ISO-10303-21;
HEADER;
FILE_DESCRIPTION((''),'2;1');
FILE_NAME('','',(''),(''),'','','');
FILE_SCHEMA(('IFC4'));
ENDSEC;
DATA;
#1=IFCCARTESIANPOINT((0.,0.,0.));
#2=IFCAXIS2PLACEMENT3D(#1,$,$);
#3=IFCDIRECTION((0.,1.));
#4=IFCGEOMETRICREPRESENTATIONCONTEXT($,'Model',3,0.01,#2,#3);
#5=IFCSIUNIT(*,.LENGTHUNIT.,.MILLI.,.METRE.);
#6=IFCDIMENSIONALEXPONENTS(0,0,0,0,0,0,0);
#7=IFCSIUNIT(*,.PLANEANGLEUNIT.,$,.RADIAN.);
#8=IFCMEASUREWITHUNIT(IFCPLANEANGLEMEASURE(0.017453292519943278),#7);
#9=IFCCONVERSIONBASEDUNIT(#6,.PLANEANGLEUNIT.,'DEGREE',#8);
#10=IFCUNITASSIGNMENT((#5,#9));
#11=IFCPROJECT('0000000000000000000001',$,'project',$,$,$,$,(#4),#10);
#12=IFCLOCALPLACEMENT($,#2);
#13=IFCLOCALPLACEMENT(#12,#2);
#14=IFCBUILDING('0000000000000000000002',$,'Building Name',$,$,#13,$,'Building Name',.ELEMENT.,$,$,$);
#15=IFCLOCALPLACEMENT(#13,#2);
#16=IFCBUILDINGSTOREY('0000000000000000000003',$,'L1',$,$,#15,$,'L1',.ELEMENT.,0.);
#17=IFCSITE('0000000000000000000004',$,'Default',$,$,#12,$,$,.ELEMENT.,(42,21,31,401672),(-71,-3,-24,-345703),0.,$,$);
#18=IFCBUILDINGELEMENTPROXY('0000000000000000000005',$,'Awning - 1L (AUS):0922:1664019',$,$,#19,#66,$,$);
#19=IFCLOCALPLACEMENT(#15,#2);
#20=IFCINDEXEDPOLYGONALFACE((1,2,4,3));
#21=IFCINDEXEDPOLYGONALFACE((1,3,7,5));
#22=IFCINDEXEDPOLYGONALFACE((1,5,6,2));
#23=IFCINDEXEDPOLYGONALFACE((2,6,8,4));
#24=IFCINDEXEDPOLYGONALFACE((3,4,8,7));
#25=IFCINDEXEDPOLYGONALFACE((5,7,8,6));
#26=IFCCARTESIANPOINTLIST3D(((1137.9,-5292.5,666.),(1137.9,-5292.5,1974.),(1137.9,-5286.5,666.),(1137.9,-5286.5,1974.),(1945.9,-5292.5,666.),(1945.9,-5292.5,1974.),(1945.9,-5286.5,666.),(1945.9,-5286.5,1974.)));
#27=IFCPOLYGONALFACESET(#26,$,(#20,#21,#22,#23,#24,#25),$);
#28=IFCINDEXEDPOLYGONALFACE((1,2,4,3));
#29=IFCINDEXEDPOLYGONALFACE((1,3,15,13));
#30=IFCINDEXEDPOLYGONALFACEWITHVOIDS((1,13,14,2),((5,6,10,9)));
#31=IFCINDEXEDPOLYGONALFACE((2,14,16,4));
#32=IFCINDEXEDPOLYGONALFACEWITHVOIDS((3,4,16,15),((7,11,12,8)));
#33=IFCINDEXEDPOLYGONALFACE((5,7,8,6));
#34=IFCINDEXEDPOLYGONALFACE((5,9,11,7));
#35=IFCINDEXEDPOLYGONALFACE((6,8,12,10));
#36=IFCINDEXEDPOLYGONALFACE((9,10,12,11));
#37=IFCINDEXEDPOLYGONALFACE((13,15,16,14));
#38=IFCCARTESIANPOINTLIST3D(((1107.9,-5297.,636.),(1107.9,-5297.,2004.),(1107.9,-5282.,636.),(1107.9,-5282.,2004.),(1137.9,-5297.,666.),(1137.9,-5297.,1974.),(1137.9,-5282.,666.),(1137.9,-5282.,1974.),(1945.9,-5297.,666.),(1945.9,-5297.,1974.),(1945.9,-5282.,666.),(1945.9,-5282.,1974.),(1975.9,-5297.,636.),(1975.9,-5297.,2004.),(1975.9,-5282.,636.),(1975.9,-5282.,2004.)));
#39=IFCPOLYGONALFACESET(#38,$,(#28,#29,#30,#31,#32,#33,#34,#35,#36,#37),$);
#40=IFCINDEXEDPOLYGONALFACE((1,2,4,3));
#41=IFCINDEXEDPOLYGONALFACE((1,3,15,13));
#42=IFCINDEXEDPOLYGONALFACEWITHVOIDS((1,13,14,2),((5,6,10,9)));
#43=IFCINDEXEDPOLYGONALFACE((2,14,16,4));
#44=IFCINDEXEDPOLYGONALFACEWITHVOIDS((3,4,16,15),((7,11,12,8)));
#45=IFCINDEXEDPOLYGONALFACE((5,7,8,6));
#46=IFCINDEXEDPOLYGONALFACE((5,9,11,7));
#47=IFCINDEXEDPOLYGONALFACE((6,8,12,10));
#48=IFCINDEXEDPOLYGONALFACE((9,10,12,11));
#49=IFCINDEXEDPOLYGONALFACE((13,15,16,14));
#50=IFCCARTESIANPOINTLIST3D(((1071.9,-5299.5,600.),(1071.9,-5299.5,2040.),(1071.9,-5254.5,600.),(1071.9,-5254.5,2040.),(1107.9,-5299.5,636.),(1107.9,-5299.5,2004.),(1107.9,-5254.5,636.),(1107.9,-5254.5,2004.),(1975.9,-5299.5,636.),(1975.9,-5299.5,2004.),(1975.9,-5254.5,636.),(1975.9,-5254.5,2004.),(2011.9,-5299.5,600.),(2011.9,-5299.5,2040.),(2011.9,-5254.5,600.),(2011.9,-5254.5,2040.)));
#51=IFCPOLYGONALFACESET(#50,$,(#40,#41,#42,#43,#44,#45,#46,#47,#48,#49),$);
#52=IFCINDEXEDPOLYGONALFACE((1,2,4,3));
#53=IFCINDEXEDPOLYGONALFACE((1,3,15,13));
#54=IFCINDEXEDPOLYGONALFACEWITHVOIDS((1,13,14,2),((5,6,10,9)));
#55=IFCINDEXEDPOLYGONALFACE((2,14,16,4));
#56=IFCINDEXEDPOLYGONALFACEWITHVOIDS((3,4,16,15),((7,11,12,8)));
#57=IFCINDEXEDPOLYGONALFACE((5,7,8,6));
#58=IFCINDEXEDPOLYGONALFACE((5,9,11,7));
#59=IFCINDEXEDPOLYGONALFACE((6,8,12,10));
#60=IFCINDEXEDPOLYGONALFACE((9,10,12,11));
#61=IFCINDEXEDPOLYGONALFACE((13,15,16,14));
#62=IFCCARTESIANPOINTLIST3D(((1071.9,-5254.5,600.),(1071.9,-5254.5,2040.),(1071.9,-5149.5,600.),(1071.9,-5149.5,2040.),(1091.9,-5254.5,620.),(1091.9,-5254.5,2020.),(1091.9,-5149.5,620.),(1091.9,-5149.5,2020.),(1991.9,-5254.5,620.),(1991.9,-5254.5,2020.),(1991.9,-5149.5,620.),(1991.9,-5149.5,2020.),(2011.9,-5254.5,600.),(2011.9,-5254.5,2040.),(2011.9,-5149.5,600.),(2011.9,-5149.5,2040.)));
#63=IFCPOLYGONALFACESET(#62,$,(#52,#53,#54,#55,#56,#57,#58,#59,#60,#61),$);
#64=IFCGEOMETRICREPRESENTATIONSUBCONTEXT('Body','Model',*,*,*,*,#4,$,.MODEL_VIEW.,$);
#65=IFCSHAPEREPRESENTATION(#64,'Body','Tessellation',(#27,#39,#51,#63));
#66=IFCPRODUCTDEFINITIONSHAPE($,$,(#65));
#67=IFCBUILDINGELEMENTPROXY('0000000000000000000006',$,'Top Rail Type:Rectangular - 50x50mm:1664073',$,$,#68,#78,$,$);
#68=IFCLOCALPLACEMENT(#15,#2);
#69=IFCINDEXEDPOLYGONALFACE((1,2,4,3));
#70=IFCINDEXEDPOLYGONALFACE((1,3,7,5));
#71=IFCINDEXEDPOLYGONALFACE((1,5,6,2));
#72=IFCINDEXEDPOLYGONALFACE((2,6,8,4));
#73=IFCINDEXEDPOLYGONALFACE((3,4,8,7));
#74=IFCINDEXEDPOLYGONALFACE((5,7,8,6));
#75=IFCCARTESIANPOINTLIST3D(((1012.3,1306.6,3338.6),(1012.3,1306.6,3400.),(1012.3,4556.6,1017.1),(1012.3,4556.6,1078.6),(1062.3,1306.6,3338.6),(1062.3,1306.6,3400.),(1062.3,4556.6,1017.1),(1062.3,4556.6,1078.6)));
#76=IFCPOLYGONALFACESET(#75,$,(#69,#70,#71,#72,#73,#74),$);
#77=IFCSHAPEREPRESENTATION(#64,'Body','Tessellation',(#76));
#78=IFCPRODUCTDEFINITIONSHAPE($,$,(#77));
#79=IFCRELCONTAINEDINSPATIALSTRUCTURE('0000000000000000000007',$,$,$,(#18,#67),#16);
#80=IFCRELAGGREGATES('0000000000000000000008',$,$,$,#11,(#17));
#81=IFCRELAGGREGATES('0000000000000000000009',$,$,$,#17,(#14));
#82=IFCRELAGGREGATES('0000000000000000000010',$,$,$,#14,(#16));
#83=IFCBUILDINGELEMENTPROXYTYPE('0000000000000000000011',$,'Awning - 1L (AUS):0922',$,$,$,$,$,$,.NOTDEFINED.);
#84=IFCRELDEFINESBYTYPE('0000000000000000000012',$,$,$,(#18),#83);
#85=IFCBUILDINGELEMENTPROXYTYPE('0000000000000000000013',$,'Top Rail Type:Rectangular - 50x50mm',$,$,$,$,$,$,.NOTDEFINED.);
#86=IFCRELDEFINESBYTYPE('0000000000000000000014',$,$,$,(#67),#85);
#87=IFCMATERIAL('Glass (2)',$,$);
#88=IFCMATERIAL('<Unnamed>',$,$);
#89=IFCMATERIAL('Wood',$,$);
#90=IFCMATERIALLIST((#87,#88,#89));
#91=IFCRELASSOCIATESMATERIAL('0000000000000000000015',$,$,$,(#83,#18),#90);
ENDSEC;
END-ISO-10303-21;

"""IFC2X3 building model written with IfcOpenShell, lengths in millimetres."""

from ifc_helpers import new_model, entity, si_unit, converted_unit, direction, frame, frame_2d, origin, place, context, subcontext, project, spatial, polyline, rectangle, outline, extrude, source, transform, mapped, material, material_list, type_object, type_shapes, element, save


model = new_model("IFC2X3")

# Units and contexts
model_context = context("Model", 3, precision=0.01, world=origin(), true_north=direction((0.0, 1.0)))
body_context = subcontext(model_context, "Body", "Model", "MODEL_VIEW")
ifc_project = project(units=[si_unit("LENGTHUNIT", "METRE", prefix="MILLI"), converted_unit("PLANEANGLEUNIT", "DEGREE", entity("IfcPlaneAngleMeasure", 0.017453292519943278), si_unit("PLANEANGLEUNIT", "RADIAN"), dimensions=[0, 0, 0, 0, 0, 0, 0])], contexts=[model_context])

# Site, building, storey
site_placement = place(None, origin())
site = spatial("IfcSite", under=ifc_project, at=site_placement, Name="Default", CompositionType="ELEMENT", RefLatitude=(42, 21, 31, 401672), RefLongitude=(-71, -3, -24, -345703), RefElevation=0.0)
building_placement = place(site_placement, origin())
building = spatial("IfcBuilding", under=site, at=building_placement, Name="Building Name", LongName="Building Name", CompositionType="ELEMENT")
storey_placement = place(building_placement, origin())
storey = spatial("IfcBuildingStorey", under=building, at=storey_placement, Name="L1", LongName="L1", CompositionType="ELEMENT", Elevation=0.0)

# Building element proxies
ifc_material_1 = material(Name="Glass (2)")
ifc_material_2 = material(Name="<Unnamed>")
ifc_material_3 = material(Name="Wood")
ifc_material_list = material_list([ifc_material_1, ifc_material_2, ifc_material_3])
building_element_proxy_type_1 = type_object("IfcBuildingElementProxyType", Name="Awning - 1L (AUS):0922", PredefinedType="NOTDEFINED", material=ifc_material_list)
shared_shape = source(origin(), body_context, "Body", "SweptSolid", [
    extrude(rectangle(XDim=6.0, YDim=808.0, at=frame_2d((0.0, 0.0), x_axis=(1.0, 0.0))), frame((326.2, 12.5, 966.0), z_axis=(0.0, 0.0, 1.0), x_axis=(0.0, 1.0, 0.0)), (0.0, 0.0, 1.0), 1308.0),
    extrude(outline(polyline([(-684.0, -434.0), (684.0, -434.0), (684.0, 434.0), (-684.0, 434.0), (-684.0, -434.0)]), holes=[polyline([(654.0, -404.0), (-654.0, -404.0), (-654.0, 404.0), (654.0, 404.0), (654.0, -404.0)])]), frame((326.2, 5.0, 1620.0), z_axis=(0.0, 1.0, 0.0), x_axis=(0.0, 0.0, 1.0)), (0.0, 0.0, 1.0), 15.0),
    extrude(outline(polyline([(-720.0, -470.0), (720.0, -470.0), (720.0, 470.0), (-720.0, 470.0), (-720.0, -470.0)]), holes=[polyline([(684.0, -434.0), (-684.0, -434.0), (-684.0, 434.0), (684.0, 434.0), (684.0, -434.0)])]), frame((326.2, -22.5, 1620.0), z_axis=(0.0, 1.0, 0.0), x_axis=(0.0, 0.0, 1.0)), (0.0, 0.0, 1.0), 45.0),
    extrude(outline(polyline([(-720.0, -470.0), (720.0, -470.0), (720.0, 470.0), (-720.0, 470.0), (-720.0, -470.0)]), holes=[polyline([(700.0, -450.0), (-700.0, -450.0), (-700.0, 450.0), (700.0, 450.0), (700.0, -450.0)])]), frame((326.2, -127.5, 1620.0), z_axis=(0.0, 1.0, 0.0), x_axis=(0.0, 0.0, 1.0)), (0.0, 0.0, 1.0), 105.0),
])
type_shapes(building_element_proxy_type_1, [shared_shape])
for number, where, z_axis, x_axis, name in (
    (1, (1868.1, -5277.0, -300.0), (0.0, 0.0, 1.0), (-1.0, 0.0, 0.0), "Awning - 1L (AUS):0922:1664019"),
):
    element("IfcBuildingElementProxy", number, at=place(storey_placement, frame(where, z_axis=z_axis, x_axis=x_axis)), inside=storey, type_object=building_element_proxy_type_1, material=ifc_material_list, Name=name, context=body_context, shape_type="MappedRepresentation", body=[
        mapped(shared_shape, transform((0.0, 0.0, 0.0), scale=1.0)),
    ])
building_element_proxy_type_2 = type_object("IfcBuildingElementProxyType", Name="Top Rail Type:Rectangular - 50x50mm", PredefinedType="NOTDEFINED")
proxy_1_placement = place(storey_placement, origin())
element("IfcBuildingElementProxy", 2, at=proxy_1_placement, inside=storey, type_object=building_element_proxy_type_2, Name="Top Rail Type:Rectangular - 50x50mm:1664073", context=body_context, shape_type="SweptSolid", body=[
    extrude(outline(polyline([(-1979.1, -25.0), (2014.8, -25.0), (1979.1, 25.0), (-2014.8, 25.0), (-1979.1, -25.0)])), frame((1012.3, 2931.6, 2208.6), z_axis=(1.0, 0.0, 0.0), x_axis=(0.0, -0.813733, 0.581238)), (0.0, 0.0, 1.0), 50.0),
])

save(model, "model.ifc")
